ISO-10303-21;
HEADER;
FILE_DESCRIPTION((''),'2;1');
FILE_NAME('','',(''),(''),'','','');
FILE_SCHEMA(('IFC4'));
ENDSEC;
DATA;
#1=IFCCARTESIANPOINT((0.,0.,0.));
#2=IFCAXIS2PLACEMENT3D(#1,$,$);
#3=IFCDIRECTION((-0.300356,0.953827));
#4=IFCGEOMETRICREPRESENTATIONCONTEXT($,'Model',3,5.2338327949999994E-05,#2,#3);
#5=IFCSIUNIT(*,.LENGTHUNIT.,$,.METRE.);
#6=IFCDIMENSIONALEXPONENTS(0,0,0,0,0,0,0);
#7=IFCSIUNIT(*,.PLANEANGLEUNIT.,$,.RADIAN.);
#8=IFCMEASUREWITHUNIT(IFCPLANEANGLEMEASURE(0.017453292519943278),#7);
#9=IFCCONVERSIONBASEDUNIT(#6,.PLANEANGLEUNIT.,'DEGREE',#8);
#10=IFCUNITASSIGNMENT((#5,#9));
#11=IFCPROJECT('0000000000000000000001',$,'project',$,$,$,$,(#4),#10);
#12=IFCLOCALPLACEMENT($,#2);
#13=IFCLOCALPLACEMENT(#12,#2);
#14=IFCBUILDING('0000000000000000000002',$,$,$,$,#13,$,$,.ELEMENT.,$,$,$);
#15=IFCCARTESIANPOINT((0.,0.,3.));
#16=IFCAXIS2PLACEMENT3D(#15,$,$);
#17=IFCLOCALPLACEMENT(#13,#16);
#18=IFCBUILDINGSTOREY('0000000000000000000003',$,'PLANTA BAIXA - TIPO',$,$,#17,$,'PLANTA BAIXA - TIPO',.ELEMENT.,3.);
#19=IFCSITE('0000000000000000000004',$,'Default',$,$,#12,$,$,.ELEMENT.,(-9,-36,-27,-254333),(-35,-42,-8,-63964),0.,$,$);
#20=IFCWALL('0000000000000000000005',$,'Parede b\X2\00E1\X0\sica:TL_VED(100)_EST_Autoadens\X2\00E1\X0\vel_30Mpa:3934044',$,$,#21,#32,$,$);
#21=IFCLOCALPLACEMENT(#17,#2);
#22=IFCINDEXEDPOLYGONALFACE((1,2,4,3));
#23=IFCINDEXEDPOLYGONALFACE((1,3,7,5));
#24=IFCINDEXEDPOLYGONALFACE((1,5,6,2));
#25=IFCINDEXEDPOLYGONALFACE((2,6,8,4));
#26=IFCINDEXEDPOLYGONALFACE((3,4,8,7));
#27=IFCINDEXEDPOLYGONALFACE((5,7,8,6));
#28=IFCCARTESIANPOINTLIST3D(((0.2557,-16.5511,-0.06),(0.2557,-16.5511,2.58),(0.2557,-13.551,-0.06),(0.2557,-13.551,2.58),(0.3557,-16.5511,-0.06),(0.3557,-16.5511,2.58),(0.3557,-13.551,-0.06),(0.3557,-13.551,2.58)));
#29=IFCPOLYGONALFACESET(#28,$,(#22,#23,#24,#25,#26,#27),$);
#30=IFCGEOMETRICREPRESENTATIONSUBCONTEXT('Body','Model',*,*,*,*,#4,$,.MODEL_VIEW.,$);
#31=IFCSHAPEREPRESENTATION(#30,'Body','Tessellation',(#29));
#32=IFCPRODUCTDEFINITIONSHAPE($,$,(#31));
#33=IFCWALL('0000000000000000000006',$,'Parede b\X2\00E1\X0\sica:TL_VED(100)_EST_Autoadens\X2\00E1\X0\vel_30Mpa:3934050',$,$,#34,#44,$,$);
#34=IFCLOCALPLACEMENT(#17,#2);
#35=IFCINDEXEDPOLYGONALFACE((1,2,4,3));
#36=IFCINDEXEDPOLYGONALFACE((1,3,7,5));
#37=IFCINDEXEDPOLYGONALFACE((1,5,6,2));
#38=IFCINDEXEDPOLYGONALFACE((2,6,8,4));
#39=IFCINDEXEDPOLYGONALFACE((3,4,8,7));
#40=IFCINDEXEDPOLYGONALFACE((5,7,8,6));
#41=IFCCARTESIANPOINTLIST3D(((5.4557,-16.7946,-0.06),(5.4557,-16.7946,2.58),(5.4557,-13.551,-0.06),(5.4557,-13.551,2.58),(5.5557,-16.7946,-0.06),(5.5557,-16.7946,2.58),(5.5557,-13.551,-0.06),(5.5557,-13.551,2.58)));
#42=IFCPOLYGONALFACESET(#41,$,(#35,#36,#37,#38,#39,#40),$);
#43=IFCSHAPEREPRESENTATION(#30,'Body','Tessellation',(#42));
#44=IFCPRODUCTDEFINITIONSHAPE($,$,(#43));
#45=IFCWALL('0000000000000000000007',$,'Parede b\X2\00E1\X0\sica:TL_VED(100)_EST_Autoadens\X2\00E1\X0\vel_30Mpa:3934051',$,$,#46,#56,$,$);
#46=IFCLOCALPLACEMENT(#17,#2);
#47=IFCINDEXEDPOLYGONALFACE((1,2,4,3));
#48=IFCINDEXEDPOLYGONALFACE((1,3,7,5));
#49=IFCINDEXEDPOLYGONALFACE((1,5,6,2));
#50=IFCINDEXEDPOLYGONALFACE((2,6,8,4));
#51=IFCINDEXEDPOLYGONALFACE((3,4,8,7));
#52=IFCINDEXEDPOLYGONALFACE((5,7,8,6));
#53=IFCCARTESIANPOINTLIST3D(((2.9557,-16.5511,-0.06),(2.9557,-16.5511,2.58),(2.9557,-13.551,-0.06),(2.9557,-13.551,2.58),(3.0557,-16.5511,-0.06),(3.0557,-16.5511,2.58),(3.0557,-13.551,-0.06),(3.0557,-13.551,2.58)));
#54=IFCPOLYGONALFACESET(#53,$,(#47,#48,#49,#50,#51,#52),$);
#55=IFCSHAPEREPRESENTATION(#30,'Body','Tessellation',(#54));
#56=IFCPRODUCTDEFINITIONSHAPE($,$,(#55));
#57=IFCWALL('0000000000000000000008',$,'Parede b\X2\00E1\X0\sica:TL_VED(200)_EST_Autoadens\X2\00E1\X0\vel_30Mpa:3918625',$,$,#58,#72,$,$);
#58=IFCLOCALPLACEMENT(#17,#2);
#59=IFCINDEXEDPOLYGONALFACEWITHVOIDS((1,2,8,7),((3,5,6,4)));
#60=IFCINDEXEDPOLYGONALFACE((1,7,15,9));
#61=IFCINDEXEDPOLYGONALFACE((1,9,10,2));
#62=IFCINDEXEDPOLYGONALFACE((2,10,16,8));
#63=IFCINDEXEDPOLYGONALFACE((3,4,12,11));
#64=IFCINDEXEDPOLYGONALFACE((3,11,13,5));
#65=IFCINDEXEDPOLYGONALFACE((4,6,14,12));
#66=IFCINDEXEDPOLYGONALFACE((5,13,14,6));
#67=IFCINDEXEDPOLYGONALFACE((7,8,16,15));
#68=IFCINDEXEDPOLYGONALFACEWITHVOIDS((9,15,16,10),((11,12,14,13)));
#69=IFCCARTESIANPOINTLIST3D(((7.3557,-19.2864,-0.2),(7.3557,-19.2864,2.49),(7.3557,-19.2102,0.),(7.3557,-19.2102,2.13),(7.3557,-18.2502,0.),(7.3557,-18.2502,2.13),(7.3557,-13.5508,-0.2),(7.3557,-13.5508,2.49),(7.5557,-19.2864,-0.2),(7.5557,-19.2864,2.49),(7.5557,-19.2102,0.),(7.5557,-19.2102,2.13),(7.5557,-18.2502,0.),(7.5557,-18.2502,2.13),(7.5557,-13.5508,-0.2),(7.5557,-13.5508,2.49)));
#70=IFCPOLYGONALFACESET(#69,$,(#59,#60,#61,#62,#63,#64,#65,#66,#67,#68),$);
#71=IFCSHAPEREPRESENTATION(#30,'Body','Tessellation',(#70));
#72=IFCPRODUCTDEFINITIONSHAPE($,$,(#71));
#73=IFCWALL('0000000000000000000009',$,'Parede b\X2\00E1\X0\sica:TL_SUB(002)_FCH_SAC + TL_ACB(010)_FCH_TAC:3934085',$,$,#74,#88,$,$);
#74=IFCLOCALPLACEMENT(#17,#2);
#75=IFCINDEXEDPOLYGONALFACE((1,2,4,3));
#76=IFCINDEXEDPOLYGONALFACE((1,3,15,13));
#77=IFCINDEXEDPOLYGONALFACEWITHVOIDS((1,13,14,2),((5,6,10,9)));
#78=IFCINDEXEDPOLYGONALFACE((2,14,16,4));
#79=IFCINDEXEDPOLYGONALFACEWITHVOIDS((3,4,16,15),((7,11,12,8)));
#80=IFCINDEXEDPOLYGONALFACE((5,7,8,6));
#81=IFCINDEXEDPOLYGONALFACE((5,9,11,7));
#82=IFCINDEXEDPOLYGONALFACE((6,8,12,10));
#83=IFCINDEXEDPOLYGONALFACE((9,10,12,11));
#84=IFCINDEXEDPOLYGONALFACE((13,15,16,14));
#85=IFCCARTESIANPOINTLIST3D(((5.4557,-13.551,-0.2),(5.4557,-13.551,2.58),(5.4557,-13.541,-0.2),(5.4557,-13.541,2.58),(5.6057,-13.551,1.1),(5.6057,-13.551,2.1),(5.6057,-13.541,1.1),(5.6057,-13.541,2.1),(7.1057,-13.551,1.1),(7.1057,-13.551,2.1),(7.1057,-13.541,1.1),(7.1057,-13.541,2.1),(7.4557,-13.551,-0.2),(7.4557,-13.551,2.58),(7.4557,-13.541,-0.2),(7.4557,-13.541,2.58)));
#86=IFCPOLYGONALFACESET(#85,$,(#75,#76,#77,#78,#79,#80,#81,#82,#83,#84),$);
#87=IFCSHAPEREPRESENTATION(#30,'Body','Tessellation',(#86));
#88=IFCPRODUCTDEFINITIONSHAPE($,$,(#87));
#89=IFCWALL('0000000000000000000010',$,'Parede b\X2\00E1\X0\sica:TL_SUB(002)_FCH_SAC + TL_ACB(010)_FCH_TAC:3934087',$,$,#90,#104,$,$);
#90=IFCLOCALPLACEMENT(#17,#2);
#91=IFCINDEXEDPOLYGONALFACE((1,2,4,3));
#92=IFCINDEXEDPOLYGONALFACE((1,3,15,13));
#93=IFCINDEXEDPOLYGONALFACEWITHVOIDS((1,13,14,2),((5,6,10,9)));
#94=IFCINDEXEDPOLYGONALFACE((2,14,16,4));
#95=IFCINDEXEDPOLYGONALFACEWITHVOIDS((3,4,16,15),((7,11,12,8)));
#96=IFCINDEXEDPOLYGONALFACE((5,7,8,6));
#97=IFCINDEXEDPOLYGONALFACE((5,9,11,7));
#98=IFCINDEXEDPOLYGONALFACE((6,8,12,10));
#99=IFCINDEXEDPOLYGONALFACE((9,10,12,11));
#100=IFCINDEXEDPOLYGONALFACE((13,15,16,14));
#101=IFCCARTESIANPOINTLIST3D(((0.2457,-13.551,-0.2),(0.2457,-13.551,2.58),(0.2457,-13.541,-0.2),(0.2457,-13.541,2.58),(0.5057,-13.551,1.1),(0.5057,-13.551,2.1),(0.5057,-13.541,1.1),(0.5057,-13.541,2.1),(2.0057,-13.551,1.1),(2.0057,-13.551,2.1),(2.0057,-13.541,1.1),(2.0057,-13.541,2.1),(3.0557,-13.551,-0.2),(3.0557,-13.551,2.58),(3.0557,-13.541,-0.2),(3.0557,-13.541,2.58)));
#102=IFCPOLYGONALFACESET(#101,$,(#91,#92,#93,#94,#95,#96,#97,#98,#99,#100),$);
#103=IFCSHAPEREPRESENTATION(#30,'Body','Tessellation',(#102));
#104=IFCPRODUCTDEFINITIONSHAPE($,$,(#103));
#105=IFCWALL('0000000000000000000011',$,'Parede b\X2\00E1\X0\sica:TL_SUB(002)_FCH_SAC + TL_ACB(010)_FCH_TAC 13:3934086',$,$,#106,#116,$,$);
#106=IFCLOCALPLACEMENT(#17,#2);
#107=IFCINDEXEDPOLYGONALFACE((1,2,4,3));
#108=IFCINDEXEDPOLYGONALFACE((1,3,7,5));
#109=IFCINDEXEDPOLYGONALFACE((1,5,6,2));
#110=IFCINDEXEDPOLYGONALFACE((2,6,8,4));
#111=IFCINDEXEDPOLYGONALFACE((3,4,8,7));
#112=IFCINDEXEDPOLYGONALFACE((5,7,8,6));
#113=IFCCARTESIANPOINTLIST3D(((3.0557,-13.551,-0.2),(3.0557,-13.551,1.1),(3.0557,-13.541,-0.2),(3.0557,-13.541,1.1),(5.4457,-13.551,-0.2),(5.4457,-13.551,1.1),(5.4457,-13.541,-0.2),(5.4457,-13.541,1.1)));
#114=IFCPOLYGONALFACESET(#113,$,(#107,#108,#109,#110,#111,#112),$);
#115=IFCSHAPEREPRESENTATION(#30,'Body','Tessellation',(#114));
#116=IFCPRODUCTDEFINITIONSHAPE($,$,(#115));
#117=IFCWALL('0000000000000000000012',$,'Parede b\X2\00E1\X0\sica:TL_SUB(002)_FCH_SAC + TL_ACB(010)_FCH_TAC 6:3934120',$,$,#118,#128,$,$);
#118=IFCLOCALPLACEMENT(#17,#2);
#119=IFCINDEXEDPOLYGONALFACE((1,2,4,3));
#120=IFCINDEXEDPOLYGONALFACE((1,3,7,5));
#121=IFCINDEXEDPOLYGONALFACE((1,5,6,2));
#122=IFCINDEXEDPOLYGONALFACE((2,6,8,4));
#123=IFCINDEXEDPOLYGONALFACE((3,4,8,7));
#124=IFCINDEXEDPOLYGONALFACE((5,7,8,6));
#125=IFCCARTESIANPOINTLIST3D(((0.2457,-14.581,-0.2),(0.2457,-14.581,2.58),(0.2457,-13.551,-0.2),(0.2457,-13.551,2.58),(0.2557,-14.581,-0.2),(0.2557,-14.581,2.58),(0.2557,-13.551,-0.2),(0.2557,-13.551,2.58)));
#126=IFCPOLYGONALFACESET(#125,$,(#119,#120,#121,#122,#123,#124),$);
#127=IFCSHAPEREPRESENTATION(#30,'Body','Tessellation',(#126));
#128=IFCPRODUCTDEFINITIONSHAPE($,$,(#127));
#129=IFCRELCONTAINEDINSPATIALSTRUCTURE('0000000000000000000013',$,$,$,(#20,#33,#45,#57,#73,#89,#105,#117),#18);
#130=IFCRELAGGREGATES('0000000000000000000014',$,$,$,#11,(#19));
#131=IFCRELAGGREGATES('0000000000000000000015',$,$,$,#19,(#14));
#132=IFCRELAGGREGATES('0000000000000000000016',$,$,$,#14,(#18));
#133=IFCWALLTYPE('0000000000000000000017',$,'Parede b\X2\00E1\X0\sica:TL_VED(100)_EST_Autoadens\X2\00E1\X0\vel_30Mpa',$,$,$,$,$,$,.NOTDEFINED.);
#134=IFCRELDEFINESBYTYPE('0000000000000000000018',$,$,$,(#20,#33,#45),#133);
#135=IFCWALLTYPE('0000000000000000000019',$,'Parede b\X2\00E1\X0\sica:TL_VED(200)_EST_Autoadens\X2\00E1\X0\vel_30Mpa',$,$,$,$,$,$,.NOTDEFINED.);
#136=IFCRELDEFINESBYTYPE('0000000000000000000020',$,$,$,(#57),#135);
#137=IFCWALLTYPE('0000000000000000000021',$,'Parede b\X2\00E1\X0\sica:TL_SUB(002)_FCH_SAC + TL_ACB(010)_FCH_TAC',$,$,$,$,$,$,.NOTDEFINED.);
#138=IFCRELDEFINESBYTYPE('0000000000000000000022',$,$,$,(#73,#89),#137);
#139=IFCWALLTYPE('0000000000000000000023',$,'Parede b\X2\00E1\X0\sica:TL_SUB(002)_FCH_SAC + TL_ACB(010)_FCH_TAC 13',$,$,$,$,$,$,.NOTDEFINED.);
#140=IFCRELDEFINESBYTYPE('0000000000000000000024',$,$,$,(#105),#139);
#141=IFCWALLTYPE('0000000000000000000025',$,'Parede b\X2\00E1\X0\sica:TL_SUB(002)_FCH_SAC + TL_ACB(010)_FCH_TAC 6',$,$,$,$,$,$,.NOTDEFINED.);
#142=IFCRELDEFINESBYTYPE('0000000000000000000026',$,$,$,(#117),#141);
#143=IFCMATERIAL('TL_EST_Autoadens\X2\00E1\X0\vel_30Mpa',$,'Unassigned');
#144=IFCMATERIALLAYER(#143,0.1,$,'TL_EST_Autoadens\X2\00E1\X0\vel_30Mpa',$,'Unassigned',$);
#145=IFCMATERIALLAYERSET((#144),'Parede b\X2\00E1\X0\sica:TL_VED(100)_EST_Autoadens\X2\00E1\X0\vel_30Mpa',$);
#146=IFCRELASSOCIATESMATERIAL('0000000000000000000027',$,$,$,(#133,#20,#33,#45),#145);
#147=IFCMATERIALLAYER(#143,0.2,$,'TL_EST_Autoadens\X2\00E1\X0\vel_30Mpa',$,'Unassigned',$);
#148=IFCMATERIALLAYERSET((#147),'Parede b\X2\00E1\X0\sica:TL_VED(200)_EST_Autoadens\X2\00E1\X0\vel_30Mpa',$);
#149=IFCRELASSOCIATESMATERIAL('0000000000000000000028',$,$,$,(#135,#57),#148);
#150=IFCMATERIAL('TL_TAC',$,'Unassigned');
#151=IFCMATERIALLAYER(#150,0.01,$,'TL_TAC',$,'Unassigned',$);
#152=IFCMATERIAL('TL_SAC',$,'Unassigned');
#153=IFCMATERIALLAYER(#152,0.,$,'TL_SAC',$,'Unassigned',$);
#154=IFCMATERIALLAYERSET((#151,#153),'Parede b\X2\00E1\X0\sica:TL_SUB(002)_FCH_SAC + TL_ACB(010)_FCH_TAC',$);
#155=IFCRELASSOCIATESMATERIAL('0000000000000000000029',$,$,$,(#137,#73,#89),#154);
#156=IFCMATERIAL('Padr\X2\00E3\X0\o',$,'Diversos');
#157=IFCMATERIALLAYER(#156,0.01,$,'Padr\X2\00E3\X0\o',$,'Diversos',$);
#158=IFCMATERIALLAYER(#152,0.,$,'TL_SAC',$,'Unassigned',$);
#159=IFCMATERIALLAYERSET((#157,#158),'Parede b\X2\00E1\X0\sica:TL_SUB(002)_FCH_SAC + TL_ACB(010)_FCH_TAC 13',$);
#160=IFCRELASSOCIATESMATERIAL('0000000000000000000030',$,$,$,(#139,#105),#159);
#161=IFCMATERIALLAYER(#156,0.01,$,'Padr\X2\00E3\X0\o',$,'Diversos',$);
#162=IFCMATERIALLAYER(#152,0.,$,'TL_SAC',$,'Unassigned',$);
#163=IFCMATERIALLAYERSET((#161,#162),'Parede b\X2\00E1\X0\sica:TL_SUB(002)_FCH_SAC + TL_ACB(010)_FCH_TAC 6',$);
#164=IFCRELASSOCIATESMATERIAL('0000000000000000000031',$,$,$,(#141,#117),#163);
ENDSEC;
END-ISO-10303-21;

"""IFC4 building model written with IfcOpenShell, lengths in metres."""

from ifc_helpers import new_model, entity, si_unit, converted_unit, direction, frame, frame_2d, origin, place, context, subcontext, project, spatial, rectangle, extrude, material, layer, layer_set, layer_usage, type_object, element, save


model = new_model("IFC4")

# Units and contexts
model_context = context("Model", 3, precision=5.2338327949999994e-05, world=origin(), true_north=direction((-0.300356, 0.953827)))
body_context = subcontext(model_context, "Body", "Model", "MODEL_VIEW")
ifc_project = project(units=[si_unit("LENGTHUNIT", "METRE"), converted_unit("PLANEANGLEUNIT", "DEGREE", entity("IfcPlaneAngleMeasure", 0.017453292519943278), si_unit("PLANEANGLEUNIT", "RADIAN"), dimensions=[0, 0, 0, 0, 0, 0, 0])], contexts=[model_context])

# Site, building, storey
site_placement = place(None, origin())
site = spatial("IfcSite", under=ifc_project, at=site_placement, Name="Default", CompositionType="ELEMENT", RefLatitude=(-9, -36, -27, -254333), RefLongitude=(-35, -42, -8, -63964), RefElevation=0.0)
building_placement = place(site_placement, origin())
building = spatial("IfcBuilding", under=site, at=building_placement, CompositionType="ELEMENT")
storey_placement = place(building_placement, frame((0.0, 0.0, 3.0)))
storey = spatial("IfcBuildingStorey", under=building, at=storey_placement, Name="PLANTA BAIXA - TIPO", LongName="PLANTA BAIXA - TIPO", CompositionType="ELEMENT", Elevation=3.0)

# Walls
ifc_material_1 = material(Name="TL_EST_Autoadensável_30Mpa", Category="Unassigned")
ifc_layer_1 = layer(ifc_material_1, 0.1, Name="TL_EST_Autoadensável_30Mpa", Category="Unassigned")
ifc_layer_set_1 = layer_set([ifc_layer_1], Name="Parede básica:TL_VED(100)_EST_Autoadensável_30Mpa")
ifc_layer_usage_1 = layer_usage(ifc_layer_set_1, "AXIS2", "NEGATIVE", 0.05)
wall_type_1 = type_object("IfcWallType", Name="Parede básica:TL_VED(100)_EST_Autoadensável_30Mpa", PredefinedType="NOTDEFINED", material=ifc_layer_set_1)
wall_1_placement = place(storey_placement, frame((0.3057, -13.551, -0.06), z_axis=(0.0, 0.0, 1.0), x_axis=(0.0, -1.0, 0.0)))
element("IfcWall", 1, at=wall_1_placement, inside=storey, type_object=wall_type_1, material=ifc_layer_usage_1, Name="Parede básica:TL_VED(100)_EST_Autoadensável_30Mpa:3934044", context=body_context, shape_type="SweptSolid", body=[
    extrude(rectangle(XDim=3.0001, YDim=0.1, at=frame_2d((1.5001, 0.0), x_axis=(-1.0, 0.0))), origin(), (0.0, 0.0, 1.0), 2.64),
])
ifc_layer_usage_2 = layer_usage(ifc_layer_set_1, "AXIS2", "NEGATIVE", 0.05)
wall_2_placement = place(storey_placement, frame((5.5057, -13.551, -0.06), z_axis=(0.0, 0.0, 1.0), x_axis=(0.0, -1.0, 0.0)))
element("IfcWall", 2, at=wall_2_placement, inside=storey, type_object=wall_type_1, material=ifc_layer_usage_2, Name="Parede básica:TL_VED(100)_EST_Autoadensável_30Mpa:3934050", context=body_context, shape_type="SweptSolid", body=[
    extrude(rectangle(XDim=3.2437, YDim=0.1, at=frame_2d((1.6218, 0.0), x_axis=(-1.0, 0.0))), origin(), (0.0, 0.0, 1.0), 2.64),
])

# Walls, openings
ifc_layer_usage_3 = layer_usage(ifc_layer_set_1, "AXIS2", "NEGATIVE", 0.05)
wall_3_placement = place(storey_placement, frame((3.0057, -13.551, -0.06), z_axis=(0.0, 0.0, 1.0), x_axis=(0.0, -1.0, 0.0)))
wall_3 = element("IfcWall", 3, at=wall_3_placement, inside=storey, type_object=wall_type_1, material=ifc_layer_usage_3, Name="Parede básica:TL_VED(100)_EST_Autoadensável_30Mpa:3934051", context=body_context, shape_type="SweptSolid", body=[
    extrude(rectangle(XDim=3.0001, YDim=0.1, at=frame_2d((1.5001, 0.0), x_axis=(-1.0, 0.0))), origin(), (0.0, 0.0, 1.0), 2.64),
])
opening_1_placement = place(wall_3_placement, frame((-13.551, -3.0057, 0.06)))
element("IfcOpeningElement", 4, at=opening_1_placement, cuts=wall_3, PredefinedType="OPENING", context=body_context, shape_type="SweptSolid", body=[
    extrude(rectangle(XDim=2.1, YDim=0.1, at=frame_2d((0.0, 0.0), x_axis=(0.0, 1.0))), frame((14.501, 3.0557, 1.05), z_axis=(0.0, 1.0, 0.0), x_axis=(1.0, 0.0, 0.0)), (0.0, 0.0, 1.0), 2.4),
])
ifc_layer_2 = layer(ifc_material_1, 0.2, Name="TL_EST_Autoadensável_30Mpa", Category="Unassigned")
ifc_layer_set_2 = layer_set([ifc_layer_2], Name="Parede básica:TL_VED(200)_EST_Autoadensável_30Mpa")
ifc_layer_usage_4 = layer_usage(ifc_layer_set_2, "AXIS2", "NEGATIVE", 0.1)
wall_type_2 = type_object("IfcWallType", Name="Parede básica:TL_VED(200)_EST_Autoadensável_30Mpa", PredefinedType="NOTDEFINED", material=ifc_layer_set_2)
wall_4_placement = place(storey_placement, frame((7.4557, -13.5508, -0.2), z_axis=(0.0, 0.0, 1.0), x_axis=(0.0, -1.0, 0.0)))
wall_4 = element("IfcWall", 5, at=wall_4_placement, inside=storey, type_object=wall_type_2, material=ifc_layer_usage_4, Name="Parede básica:TL_VED(200)_EST_Autoadensável_30Mpa:3918625", context=body_context, shape_type="SweptSolid", body=[
    extrude(rectangle(XDim=5.7355, YDim=0.2, at=frame_2d((2.8678, 0.0), x_axis=(-1.0, 0.0))), origin(), (0.0, 0.0, 1.0), 2.69),
])
opening_2_placement = place(wall_4_placement, frame((5.6593, 0.1, 0.2)))
element("IfcOpeningElement", 6, at=opening_2_placement, cuts=wall_4, PredefinedType="OPENING", context=body_context, shape_type="SweptSolid", body=[
    extrude(rectangle(XDim=2.13, YDim=0.96, at=frame_2d((1.065, 0.48), x_axis=(1.0, 0.0))), frame((0.0, 0.0, 0.0), z_axis=(0.0, -1.0, 0.0), x_axis=(0.0, 0.0, 1.0)), (0.0, 0.0, 1.0), 0.2),
])
ifc_material_2 = material(Name="TL_TAC", Category="Unassigned")
ifc_layer_3 = layer(ifc_material_2, 0.01, Name="TL_TAC", Category="Unassigned")
ifc_material_3 = material(Name="TL_SAC", Category="Unassigned")
ifc_layer_4 = layer(ifc_material_3, 0.0, Name="TL_SAC", Category="Unassigned")
ifc_layer_set_3 = layer_set([ifc_layer_3, ifc_layer_4], Name="Parede básica:TL_SUB(002)_FCH_SAC + TL_ACB(010)_FCH_TAC")
ifc_layer_usage_5 = layer_usage(ifc_layer_set_3, "AXIS2", "NEGATIVE", 0.005)
wall_type_3 = type_object("IfcWallType", Name="Parede básica:TL_SUB(002)_FCH_SAC + TL_ACB(010)_FCH_TAC", PredefinedType="NOTDEFINED", material=ifc_layer_set_3)
wall_5_placement = place(storey_placement, frame((7.4557, -13.546, -0.2), z_axis=(0.0, 0.0, 1.0), x_axis=(-1.0, 0.0, 0.0)))
wall_5 = element("IfcWall", 7, at=wall_5_placement, inside=storey, type_object=wall_type_3, material=ifc_layer_usage_5, Name="Parede básica:TL_SUB(002)_FCH_SAC + TL_ACB(010)_FCH_TAC:3934085", context=body_context, shape_type="SweptSolid", body=[
    extrude(rectangle(XDim=2.0, YDim=0.01, at=frame_2d((1.0, 0.0), x_axis=(-1.0, 0.0))), origin(), (0.0, 0.0, 1.0), 2.78),
])
opening_3_placement = place(wall_5_placement, frame((7.4557, -13.546, 1.3)))
element("IfcOpeningElement", 8, at=opening_3_placement, cuts=wall_5, PredefinedType="OPENING", context=body_context, shape_type="SweptSolid", body=[
    extrude(rectangle(XDim=1.0, YDim=1.5, at=frame_2d((0.0, 0.0), x_axis=(0.0, 1.0))), frame((-6.3557, 12.127, 0.5), z_axis=(0.0, 1.0, 0.0), x_axis=(1.0, 0.0, 0.0)), (0.0, 0.0, 1.0), 3.048),
])
ifc_layer_usage_6 = layer_usage(ifc_layer_set_3, "AXIS2", "POSITIVE", -0.005)
wall_6_placement = place(storey_placement, frame((3.0557, -13.546, -0.2), z_axis=(0.0, 0.0, 1.0), x_axis=(-1.0, 0.0, 0.0)))
wall_6 = element("IfcWall", 9, at=wall_6_placement, inside=storey, type_object=wall_type_3, material=ifc_layer_usage_6, Name="Parede básica:TL_SUB(002)_FCH_SAC + TL_ACB(010)_FCH_TAC:3934087", context=body_context, shape_type="SweptSolid", body=[
    extrude(rectangle(XDim=2.81, YDim=0.01, at=frame_2d((1.405, 0.0), x_axis=(-1.0, 0.0))), origin(), (0.0, 0.0, 1.0), 2.78),
])
opening_4_placement = place(wall_6_placement, frame((3.0557, -13.546, 1.3)))
element("IfcOpeningElement", 10, at=opening_4_placement, cuts=wall_6, PredefinedType="OPENING", context=body_context, shape_type="SweptSolid", body=[
    extrude(rectangle(XDim=1.0, YDim=1.5, at=frame_2d((0.0, 0.0), x_axis=(0.0, 1.0))), frame((-1.2557, 12.127, 0.5), z_axis=(0.0, 1.0, 0.0), x_axis=(1.0, 0.0, 0.0)), (0.0, 0.0, 1.0), 3.048),
])

# Walls
ifc_material_4 = material(Name="Padrão", Category="Diversos")
ifc_layer_5 = layer(ifc_material_4, 0.01, Name="Padrão", Category="Diversos")
ifc_layer_6 = layer(ifc_material_3, 0.0, Name="TL_SAC", Category="Unassigned")
ifc_layer_set_4 = layer_set([ifc_layer_5, ifc_layer_6], Name="Parede básica:TL_SUB(002)_FCH_SAC + TL_ACB(010)_FCH_TAC 13")
ifc_layer_usage_7 = layer_usage(ifc_layer_set_4, "AXIS2", "NEGATIVE", 0.005)
wall_type_4 = type_object("IfcWallType", Name="Parede básica:TL_SUB(002)_FCH_SAC + TL_ACB(010)_FCH_TAC 13", PredefinedType="NOTDEFINED", material=ifc_layer_set_4)
wall_7_placement = place(storey_placement, frame((5.4457, -13.546, -0.2), z_axis=(0.0, 0.0, 1.0), x_axis=(-1.0, 0.0, 0.0)))
element("IfcWall", 11, at=wall_7_placement, inside=storey, type_object=wall_type_4, material=ifc_layer_usage_7, Name="Parede básica:TL_SUB(002)_FCH_SAC + TL_ACB(010)_FCH_TAC 13:3934086", context=body_context, shape_type="SweptSolid", body=[
    extrude(rectangle(XDim=2.39, YDim=0.01, at=frame_2d((1.195, 0.0), x_axis=(-1.0, 0.0))), origin(), (0.0, 0.0, 1.0), 1.3),
])
ifc_layer_7 = layer(ifc_material_4, 0.01, Name="Padrão", Category="Diversos")
ifc_layer_8 = layer(ifc_material_3, 0.0, Name="TL_SAC", Category="Unassigned")
ifc_layer_set_5 = layer_set([ifc_layer_7, ifc_layer_8], Name="Parede básica:TL_SUB(002)_FCH_SAC + TL_ACB(010)_FCH_TAC 6")
ifc_layer_usage_8 = layer_usage(ifc_layer_set_5, "AXIS2", "NEGATIVE", 0.005)
wall_type_5 = type_object("IfcWallType", Name="Parede básica:TL_SUB(002)_FCH_SAC + TL_ACB(010)_FCH_TAC 6", PredefinedType="NOTDEFINED", material=ifc_layer_set_5)
wall_8_placement = place(storey_placement, frame((0.2507, -13.551, -0.2), z_axis=(0.0, 0.0, 1.0), x_axis=(0.0, -1.0, 0.0)))
element("IfcWall", 12, at=wall_8_placement, inside=storey, type_object=wall_type_5, material=ifc_layer_usage_8, Name="Parede básica:TL_SUB(002)_FCH_SAC + TL_ACB(010)_FCH_TAC 6:3934120", context=body_context, shape_type="SweptSolid", body=[
    extrude(rectangle(XDim=1.03, YDim=0.01, at=frame_2d((0.515, 0.0), x_axis=(-1.0, 0.0))), origin(), (0.0, 0.0, 1.0), 2.78),
])

save(model, "model.ifc")
